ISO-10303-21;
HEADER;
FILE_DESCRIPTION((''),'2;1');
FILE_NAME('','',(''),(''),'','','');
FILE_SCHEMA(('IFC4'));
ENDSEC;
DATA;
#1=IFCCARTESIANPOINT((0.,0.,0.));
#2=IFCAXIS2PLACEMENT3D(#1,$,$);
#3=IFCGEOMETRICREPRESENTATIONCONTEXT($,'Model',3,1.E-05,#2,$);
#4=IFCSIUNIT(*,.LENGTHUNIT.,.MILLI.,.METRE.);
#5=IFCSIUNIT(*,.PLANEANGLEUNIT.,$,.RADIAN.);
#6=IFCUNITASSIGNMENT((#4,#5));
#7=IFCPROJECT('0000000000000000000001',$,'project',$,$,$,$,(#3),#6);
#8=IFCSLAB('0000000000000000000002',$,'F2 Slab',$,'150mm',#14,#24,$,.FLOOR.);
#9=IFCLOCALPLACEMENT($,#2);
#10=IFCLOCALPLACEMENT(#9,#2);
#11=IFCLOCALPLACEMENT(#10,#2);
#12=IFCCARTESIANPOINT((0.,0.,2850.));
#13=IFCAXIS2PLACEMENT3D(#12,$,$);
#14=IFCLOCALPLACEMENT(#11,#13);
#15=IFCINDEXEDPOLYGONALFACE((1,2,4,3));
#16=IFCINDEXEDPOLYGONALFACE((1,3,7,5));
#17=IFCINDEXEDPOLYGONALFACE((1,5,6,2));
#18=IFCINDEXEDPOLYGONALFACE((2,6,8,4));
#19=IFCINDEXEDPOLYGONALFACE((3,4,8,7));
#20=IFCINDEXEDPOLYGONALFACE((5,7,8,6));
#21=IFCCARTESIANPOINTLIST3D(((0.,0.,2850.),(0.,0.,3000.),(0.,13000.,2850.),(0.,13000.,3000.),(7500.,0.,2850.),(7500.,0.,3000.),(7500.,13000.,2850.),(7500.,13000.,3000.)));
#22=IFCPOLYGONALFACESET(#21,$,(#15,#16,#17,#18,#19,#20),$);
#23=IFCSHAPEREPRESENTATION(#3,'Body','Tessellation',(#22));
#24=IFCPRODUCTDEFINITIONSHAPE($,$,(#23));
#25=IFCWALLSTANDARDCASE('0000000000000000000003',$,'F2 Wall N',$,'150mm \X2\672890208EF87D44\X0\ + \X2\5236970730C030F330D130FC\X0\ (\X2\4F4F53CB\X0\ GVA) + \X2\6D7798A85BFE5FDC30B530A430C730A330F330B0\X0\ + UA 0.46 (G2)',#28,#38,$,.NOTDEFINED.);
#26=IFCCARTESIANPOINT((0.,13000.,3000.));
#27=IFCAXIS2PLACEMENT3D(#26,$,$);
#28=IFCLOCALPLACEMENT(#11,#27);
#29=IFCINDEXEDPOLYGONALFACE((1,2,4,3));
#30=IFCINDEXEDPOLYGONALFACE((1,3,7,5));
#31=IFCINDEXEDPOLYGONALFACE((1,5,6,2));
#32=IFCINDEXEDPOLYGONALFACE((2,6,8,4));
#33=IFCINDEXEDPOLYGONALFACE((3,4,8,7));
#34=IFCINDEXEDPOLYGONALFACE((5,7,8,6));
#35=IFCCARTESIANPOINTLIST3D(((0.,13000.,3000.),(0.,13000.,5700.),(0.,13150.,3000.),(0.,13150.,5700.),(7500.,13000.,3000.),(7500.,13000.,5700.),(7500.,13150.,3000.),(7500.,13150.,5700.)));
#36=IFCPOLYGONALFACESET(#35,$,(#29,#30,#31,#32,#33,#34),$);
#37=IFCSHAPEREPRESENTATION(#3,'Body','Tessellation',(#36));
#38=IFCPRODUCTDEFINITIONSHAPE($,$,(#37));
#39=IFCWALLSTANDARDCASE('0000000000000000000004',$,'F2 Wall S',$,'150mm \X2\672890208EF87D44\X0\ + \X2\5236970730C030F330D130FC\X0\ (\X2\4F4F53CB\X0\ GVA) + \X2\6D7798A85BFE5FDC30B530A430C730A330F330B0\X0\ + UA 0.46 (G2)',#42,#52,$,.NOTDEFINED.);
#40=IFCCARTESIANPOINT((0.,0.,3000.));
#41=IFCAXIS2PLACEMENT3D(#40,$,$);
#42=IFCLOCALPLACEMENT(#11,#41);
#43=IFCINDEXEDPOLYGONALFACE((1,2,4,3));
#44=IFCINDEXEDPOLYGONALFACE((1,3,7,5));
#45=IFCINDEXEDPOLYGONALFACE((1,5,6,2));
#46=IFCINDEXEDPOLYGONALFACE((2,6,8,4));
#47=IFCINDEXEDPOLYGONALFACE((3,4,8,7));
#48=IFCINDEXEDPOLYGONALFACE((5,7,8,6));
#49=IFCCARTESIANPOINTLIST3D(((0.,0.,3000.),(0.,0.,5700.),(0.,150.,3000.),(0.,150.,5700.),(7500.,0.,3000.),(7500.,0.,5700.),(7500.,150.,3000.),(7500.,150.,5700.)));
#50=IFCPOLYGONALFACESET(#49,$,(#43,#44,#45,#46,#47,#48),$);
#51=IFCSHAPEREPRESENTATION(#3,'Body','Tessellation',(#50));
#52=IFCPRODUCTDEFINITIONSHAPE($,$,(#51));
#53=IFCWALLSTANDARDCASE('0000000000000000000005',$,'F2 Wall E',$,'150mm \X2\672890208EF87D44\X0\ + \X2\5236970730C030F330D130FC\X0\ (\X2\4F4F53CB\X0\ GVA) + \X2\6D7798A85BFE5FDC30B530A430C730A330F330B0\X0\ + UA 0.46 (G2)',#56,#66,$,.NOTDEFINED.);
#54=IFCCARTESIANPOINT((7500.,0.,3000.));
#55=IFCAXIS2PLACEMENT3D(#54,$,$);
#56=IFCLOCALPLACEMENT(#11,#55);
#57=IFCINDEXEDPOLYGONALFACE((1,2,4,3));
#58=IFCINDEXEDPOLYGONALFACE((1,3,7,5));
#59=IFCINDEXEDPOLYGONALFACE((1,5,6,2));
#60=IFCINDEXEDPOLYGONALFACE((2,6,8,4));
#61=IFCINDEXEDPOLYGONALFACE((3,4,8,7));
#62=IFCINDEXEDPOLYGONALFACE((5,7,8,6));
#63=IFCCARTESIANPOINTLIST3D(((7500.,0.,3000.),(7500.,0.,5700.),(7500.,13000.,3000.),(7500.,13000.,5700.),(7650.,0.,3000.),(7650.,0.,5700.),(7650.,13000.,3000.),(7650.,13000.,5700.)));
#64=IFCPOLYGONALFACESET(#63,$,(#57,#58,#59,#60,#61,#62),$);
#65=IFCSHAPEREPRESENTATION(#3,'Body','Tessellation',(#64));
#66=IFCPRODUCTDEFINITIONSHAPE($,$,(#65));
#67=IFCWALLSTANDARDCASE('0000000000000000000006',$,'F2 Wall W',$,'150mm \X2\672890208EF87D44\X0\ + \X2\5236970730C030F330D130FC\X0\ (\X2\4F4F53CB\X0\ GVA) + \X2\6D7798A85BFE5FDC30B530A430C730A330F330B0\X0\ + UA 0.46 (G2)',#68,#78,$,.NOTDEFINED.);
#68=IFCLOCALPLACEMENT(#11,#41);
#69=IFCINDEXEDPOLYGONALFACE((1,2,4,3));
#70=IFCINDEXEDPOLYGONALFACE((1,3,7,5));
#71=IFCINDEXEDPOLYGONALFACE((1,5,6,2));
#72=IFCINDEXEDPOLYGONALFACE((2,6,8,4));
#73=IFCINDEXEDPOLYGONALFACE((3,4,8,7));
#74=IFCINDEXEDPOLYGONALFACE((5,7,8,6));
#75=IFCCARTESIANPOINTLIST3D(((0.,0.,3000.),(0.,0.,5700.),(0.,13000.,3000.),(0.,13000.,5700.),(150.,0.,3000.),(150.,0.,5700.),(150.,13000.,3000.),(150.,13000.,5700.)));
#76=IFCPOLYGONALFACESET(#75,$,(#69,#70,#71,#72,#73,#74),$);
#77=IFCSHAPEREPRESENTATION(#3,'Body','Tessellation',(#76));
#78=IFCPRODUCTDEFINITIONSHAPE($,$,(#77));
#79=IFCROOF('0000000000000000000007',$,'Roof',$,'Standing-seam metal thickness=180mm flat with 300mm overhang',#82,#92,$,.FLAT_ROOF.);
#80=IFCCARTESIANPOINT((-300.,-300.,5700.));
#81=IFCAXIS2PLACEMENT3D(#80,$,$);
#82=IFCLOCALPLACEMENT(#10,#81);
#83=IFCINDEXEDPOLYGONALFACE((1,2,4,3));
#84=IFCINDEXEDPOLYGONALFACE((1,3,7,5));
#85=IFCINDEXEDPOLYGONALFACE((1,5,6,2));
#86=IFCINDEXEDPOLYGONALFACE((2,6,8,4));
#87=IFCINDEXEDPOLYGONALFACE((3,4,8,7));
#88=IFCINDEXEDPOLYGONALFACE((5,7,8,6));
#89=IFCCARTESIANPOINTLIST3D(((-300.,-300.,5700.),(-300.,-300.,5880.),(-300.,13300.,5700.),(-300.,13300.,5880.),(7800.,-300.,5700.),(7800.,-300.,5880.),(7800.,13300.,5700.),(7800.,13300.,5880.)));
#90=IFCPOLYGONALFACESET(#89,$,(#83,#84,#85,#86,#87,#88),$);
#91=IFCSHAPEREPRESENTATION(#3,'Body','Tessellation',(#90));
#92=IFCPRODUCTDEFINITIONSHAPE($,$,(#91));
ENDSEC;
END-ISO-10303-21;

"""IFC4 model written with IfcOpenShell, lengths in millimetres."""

from ifc_helpers import new_model, si_unit, frame, frame_2d, origin, place, context, project, rectangle, extrude, element, save


model = new_model("IFC4")

# Units and contexts
model_context = context("Model", 3, precision=1e-05, world=origin())
ifc_project = project(units=[si_unit("LENGTHUNIT", "METRE", prefix="MILLI"), si_unit("PLANEANGLEUNIT", "RADIAN")], contexts=[model_context])

# Slab
placement_1 = place(None, origin())
placement_2 = place(placement_1, origin())
placement_3 = place(placement_2, origin())
slab_placement = place(placement_3, frame((0.0, 0.0, 2850.0)))
element("IfcSlab", 1, at=slab_placement, Name="F2 Slab", ObjectType="150mm", PredefinedType="FLOOR", context=model_context, shape_type="SweptSolid", body=[
    extrude(rectangle(XDim=7500.0, YDim=13000.0, at=frame_2d((3750.0, 6500.0))), frame((0.0, 0.0, 2850.0)), (0.0, 0.0, 1.0), 150.0),
])

# Walls
wall_1_placement = place(placement_3, frame((0.0, 13000.0, 3000.0)))
element("IfcWallStandardCase", 2, at=wall_1_placement, Name="F2 Wall N", ObjectType="150mm 木造軸組 + 制震ダンパー (住友 GVA) + 海風対応サイディング + UA 0.46 (G2)", PredefinedType="NOTDEFINED", context=model_context, shape_type="SweptSolid", body=[
    extrude(rectangle(XDim=7500.0, YDim=150.0, at=frame_2d((3750.0, 75.0))), frame((0.0, 13000.0, 3000.0)), (0.0, 0.0, 1.0), 2700.0),
])
wall_2_placement = place(placement_3, frame((0.0, 0.0, 3000.0)))
element("IfcWallStandardCase", 3, at=wall_2_placement, Name="F2 Wall S", ObjectType="150mm 木造軸組 + 制震ダンパー (住友 GVA) + 海風対応サイディング + UA 0.46 (G2)", PredefinedType="NOTDEFINED", context=model_context, shape_type="SweptSolid", body=[
    extrude(rectangle(XDim=7500.0, YDim=150.0, at=frame_2d((3750.0, 75.0))), frame((0.0, 0.0, 3000.0)), (0.0, 0.0, 1.0), 2700.0),
])
wall_3_placement = place(placement_3, frame((7500.0, 0.0, 3000.0)))
element("IfcWallStandardCase", 4, at=wall_3_placement, Name="F2 Wall E", ObjectType="150mm 木造軸組 + 制震ダンパー (住友 GVA) + 海風対応サイディング + UA 0.46 (G2)", PredefinedType="NOTDEFINED", context=model_context, shape_type="SweptSolid", body=[
    extrude(rectangle(XDim=150.0, YDim=13000.0, at=frame_2d((75.0, 6500.0))), frame((7500.0, 0.0, 3000.0)), (0.0, 0.0, 1.0), 2700.0),
])
wall_4_placement = place(placement_3, frame((0.0, 0.0, 3000.0)))
element("IfcWallStandardCase", 5, at=wall_4_placement, Name="F2 Wall W", ObjectType="150mm 木造軸組 + 制震ダンパー (住友 GVA) + 海風対応サイディング + UA 0.46 (G2)", PredefinedType="NOTDEFINED", context=model_context, shape_type="SweptSolid", body=[
    extrude(rectangle(XDim=150.0, YDim=13000.0, at=frame_2d((75.0, 6500.0))), frame((0.0, 0.0, 3000.0)), (0.0, 0.0, 1.0), 2700.0),
])

# Roof
roof_placement = place(placement_2, frame((-300.0, -300.0, 5700.0)))
element("IfcRoof", 6, at=roof_placement, Name="Roof", ObjectType="Standing-seam metal thickness=180mm flat with 300mm overhang", PredefinedType="FLAT_ROOF", context=model_context, shape_type="SweptSolid", body=[
    extrude(rectangle(XDim=8100.0, YDim=13600.0, at=frame_2d((4050.0, 6800.0))), frame((-300.0, -300.0, 5700.0)), (0.0, 0.0, 1.0), 180.0),
])

save(model, "model.ifc")
